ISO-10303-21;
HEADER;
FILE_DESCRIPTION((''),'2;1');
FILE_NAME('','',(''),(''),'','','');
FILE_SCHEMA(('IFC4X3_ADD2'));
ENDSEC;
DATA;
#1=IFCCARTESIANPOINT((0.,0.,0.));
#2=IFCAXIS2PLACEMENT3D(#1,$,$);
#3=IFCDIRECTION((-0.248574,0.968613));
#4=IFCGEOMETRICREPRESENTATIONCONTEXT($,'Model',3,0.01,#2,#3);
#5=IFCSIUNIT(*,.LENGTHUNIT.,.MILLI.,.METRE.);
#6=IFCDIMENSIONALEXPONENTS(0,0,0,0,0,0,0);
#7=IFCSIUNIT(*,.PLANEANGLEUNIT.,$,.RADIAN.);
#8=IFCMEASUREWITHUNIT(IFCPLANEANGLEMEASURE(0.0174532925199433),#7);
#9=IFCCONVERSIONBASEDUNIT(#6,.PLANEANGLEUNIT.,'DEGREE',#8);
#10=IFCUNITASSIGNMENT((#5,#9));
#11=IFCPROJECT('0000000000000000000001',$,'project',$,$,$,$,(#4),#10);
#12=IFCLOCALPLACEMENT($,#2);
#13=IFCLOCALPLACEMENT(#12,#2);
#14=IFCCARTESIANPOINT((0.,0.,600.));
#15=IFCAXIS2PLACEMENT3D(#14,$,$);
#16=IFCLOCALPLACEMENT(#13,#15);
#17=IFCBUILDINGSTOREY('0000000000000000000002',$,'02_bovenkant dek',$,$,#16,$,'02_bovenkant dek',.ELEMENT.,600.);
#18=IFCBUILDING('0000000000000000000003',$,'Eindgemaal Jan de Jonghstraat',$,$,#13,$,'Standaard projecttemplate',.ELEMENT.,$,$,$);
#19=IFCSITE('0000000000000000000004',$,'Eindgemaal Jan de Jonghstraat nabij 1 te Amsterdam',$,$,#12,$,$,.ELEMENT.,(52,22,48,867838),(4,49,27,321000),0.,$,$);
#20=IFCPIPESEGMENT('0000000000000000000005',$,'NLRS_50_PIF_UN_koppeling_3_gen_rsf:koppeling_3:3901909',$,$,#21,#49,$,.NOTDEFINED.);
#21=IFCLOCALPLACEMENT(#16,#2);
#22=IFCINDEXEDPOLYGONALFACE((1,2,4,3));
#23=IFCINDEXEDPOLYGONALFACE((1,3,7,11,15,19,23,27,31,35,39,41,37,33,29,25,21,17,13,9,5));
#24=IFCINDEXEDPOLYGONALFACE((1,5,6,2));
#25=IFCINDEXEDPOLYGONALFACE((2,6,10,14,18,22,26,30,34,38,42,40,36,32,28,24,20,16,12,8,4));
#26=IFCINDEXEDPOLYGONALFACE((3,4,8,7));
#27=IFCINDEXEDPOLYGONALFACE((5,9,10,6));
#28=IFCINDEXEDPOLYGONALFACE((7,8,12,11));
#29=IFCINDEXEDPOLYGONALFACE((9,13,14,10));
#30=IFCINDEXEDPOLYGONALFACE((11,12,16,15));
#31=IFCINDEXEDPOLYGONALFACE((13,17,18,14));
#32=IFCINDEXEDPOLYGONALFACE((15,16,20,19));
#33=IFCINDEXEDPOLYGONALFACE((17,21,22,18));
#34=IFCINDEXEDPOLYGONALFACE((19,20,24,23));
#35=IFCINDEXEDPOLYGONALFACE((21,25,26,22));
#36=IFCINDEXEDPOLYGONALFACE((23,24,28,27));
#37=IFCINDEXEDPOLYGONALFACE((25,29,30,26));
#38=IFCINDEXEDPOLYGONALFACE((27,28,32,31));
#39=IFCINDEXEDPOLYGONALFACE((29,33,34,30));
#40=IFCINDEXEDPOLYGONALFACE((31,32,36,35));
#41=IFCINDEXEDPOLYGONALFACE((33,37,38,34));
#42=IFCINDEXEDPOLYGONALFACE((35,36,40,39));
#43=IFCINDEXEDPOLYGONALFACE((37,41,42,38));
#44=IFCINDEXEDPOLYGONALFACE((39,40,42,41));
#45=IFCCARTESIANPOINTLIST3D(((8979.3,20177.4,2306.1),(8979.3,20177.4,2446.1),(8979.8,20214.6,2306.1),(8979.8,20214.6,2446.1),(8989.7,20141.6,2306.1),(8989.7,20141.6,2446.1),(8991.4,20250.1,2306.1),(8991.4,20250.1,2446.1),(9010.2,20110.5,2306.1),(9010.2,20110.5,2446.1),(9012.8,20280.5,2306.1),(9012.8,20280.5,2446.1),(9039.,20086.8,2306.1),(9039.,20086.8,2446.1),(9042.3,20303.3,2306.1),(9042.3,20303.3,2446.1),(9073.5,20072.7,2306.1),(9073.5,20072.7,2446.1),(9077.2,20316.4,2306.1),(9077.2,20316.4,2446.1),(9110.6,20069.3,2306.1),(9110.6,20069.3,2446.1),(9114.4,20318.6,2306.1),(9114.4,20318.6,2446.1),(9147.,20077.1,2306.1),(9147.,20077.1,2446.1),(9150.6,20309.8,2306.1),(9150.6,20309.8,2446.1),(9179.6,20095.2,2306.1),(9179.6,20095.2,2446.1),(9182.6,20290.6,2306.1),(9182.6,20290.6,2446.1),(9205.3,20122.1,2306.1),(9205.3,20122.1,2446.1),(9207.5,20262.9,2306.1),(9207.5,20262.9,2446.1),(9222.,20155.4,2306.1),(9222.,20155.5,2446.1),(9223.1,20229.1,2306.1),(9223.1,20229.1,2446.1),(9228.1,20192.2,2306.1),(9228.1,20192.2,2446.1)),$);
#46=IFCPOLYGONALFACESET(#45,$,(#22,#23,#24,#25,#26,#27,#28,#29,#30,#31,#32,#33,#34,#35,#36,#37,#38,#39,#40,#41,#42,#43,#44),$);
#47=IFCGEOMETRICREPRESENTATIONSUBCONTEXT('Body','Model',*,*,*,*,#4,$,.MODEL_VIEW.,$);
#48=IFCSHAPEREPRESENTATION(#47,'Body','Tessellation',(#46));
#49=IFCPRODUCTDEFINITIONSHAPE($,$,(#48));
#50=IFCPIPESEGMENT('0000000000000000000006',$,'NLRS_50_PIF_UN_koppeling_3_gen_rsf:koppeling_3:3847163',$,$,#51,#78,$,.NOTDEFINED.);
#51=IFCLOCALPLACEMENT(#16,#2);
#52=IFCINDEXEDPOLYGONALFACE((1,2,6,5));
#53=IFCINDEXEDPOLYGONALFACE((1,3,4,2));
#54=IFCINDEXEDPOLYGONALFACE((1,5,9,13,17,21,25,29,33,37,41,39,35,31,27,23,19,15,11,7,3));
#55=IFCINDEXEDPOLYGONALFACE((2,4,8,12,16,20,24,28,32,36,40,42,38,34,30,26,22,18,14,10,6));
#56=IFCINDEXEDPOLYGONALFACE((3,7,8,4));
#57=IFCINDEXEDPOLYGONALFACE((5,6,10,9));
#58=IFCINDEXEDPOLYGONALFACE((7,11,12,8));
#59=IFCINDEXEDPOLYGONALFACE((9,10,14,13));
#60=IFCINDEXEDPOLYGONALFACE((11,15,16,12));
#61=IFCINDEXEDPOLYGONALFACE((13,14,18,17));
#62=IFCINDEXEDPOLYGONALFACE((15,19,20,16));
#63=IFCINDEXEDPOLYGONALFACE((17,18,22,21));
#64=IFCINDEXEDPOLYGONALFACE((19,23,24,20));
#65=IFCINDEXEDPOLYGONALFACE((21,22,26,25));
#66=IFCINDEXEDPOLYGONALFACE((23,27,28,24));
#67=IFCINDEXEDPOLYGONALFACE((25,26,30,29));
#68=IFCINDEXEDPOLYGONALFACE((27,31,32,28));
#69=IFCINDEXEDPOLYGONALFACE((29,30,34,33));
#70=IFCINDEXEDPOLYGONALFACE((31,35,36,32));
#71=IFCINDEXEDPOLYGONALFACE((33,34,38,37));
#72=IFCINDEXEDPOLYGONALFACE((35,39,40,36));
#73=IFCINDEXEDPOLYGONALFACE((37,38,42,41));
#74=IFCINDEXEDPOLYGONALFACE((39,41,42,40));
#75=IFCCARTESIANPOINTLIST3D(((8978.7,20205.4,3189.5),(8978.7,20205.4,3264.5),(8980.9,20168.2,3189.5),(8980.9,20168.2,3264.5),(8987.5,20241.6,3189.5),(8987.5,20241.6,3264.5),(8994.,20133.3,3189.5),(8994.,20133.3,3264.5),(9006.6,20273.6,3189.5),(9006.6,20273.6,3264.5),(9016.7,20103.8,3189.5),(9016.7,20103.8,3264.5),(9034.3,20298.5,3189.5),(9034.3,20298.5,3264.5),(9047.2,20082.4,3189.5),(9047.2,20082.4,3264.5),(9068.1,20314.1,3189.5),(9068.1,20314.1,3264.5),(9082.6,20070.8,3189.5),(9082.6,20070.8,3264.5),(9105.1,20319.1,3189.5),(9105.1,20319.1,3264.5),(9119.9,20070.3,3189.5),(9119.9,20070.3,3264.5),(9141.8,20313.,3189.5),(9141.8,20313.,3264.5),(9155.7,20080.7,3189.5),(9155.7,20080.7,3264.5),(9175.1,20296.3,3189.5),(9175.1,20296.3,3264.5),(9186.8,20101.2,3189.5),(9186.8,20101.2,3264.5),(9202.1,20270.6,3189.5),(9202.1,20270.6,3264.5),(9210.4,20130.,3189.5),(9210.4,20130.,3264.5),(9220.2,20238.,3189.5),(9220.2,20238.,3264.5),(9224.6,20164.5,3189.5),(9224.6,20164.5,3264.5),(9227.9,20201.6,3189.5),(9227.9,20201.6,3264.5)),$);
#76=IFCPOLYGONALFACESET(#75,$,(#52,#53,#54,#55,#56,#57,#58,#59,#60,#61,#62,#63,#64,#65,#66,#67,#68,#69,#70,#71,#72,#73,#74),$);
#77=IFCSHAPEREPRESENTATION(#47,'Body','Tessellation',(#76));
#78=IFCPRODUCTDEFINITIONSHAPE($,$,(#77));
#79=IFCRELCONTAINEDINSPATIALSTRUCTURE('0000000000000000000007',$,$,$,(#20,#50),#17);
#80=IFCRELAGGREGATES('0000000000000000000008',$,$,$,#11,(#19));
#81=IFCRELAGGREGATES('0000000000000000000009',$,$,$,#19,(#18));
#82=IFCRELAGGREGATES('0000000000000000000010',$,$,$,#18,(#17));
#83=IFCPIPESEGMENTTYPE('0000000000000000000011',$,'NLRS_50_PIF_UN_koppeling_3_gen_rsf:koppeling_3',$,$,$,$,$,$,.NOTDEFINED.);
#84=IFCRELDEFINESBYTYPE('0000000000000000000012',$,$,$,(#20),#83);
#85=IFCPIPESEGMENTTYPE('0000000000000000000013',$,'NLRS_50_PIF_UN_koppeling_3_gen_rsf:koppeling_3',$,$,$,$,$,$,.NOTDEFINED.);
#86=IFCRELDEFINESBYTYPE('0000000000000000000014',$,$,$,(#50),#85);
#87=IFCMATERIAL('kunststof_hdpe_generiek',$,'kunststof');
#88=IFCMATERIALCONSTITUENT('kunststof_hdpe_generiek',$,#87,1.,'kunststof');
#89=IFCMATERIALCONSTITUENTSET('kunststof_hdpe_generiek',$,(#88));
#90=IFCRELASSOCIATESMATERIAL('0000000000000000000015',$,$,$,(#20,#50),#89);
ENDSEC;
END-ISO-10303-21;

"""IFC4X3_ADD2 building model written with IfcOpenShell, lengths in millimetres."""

from ifc_helpers import new_model, entity, si_unit, converted_unit, direction, frame, frame_2d, origin, place, context, subcontext, project, spatial, circle, extrude, source, transform, mapped, material, constituent, constituent_set, type_object, type_shapes, element, save


model = new_model("IFC4X3_ADD2")

# Units and contexts
model_context = context("Model", 3, precision=0.01, world=origin(), true_north=direction((-0.248574, 0.968613)))
body_context = subcontext(model_context, "Body", "Model", "MODEL_VIEW")
ifc_project = project(units=[si_unit("LENGTHUNIT", "METRE", prefix="MILLI"), converted_unit("PLANEANGLEUNIT", "DEGREE", entity("IfcPlaneAngleMeasure", 0.0174532925199433), si_unit("PLANEANGLEUNIT", "RADIAN"), dimensions=[0, 0, 0, 0, 0, 0, 0])], contexts=[model_context])

# Site, building, storey
site_placement = place(None, origin())
site = spatial("IfcSite", under=ifc_project, at=site_placement, Name="Eindgemaal Jan de Jonghstraat nabij 1 te Amsterdam", CompositionType="ELEMENT", RefLatitude=(52, 22, 48, 867838), RefLongitude=(4, 49, 27, 321000), RefElevation=0.0)
building_placement = place(site_placement, origin())
building = spatial("IfcBuilding", under=site, at=building_placement, Name="Eindgemaal Jan de Jonghstraat", LongName="Standaard projecttemplate", CompositionType="ELEMENT")
storey_placement = place(building_placement, frame((0.0, 0.0, 600.0)))
storey = spatial("IfcBuildingStorey", under=building, at=storey_placement, Name="02_bovenkant dek", LongName="02_bovenkant dek", CompositionType="ELEMENT", Elevation=600.0)

# Pipe segments
ifc_material_1 = material(Name="kunststof_hdpe_generiek", Category="kunststof")
ifc_constituent_1 = constituent(ifc_material_1, Name="kunststof_hdpe_generiek", Category="kunststof", fraction=1.0)
ifc_constituent_set_1 = constituent_set(constituents=[ifc_constituent_1], Name="kunststof_hdpe_generiek")
pipe_segment_type_1 = type_object("IfcPipeSegmentType", Name="NLRS_50_PIF_UN_koppeling_3_gen_rsf:koppeling_3", PredefinedType="NOTDEFINED")
shared_shape_1 = source(origin(), body_context, "Body", "SweptSolid", [
    extrude(circle(Radius=125.0, at=frame_2d((0.0, 0.0), x_axis=(1.0, 0.0))), frame((0.0, 0.0, 0.0), z_axis=(1.0, 0.0, 0.0), x_axis=(0.0, 1.0, 0.0)), (0.0, 0.0, 1.0), 140.0),
])
type_shapes(pipe_segment_type_1, [shared_shape_1])
for number, where, z_axis, x_axis, name in (
    (1, (9103.1, 20194.1, 2446.1), (-0.668897, 0.743355, -0.000031), (-0.000002, -0.000043, -1.0), "NLRS_50_PIF_UN_koppeling_3_gen_rsf:koppeling_3:3901909"),
):
    element("IfcPipeSegment", number, at=place(storey_placement, frame(where, z_axis=z_axis, x_axis=x_axis)), inside=storey, type_object=pipe_segment_type_1, material=ifc_constituent_set_1, Name=name, PredefinedType="NOTDEFINED", context=body_context, shape_type="MappedRepresentation", body=[
        mapped(shared_shape_1, transform((0.0, 0.0, 0.0), scale=1.0)),
    ])
pipe_segment_type_2 = type_object("IfcPipeSegmentType", Name="NLRS_50_PIF_UN_koppeling_3_gen_rsf:koppeling_3", PredefinedType="NOTDEFINED")
shared_shape_2 = source(origin(), body_context, "Body", "SweptSolid", [
    extrude(circle(Radius=125.0, at=frame_2d((0.0, 0.0), x_axis=(1.0, 0.0))), frame((0.0, 0.0, 0.0), z_axis=(1.0, 0.0, 0.0), x_axis=(0.0, 1.0, 0.0)), (0.0, 0.0, 1.0), 75.0),
])
type_shapes(pipe_segment_type_2, [shared_shape_2])
pipe_segment_1_placement = place(storey_placement, frame((9103.1, 20194.2, 3264.5), z_axis=(-0.743355, -0.668897, 0.00002), x_axis=(-0.000001, -0.00003, -1.0)))
element("IfcPipeSegment", 2, at=pipe_segment_1_placement, inside=storey, type_object=pipe_segment_type_2, material=ifc_constituent_set_1, Name="NLRS_50_PIF_UN_koppeling_3_gen_rsf:koppeling_3:3847163", PredefinedType="NOTDEFINED", context=body_context, shape_type="MappedRepresentation", body=[
    mapped(shared_shape_2, transform((0.0, 0.0, 0.0), scale=1.0)),
])

save(model, "model.ifc")
